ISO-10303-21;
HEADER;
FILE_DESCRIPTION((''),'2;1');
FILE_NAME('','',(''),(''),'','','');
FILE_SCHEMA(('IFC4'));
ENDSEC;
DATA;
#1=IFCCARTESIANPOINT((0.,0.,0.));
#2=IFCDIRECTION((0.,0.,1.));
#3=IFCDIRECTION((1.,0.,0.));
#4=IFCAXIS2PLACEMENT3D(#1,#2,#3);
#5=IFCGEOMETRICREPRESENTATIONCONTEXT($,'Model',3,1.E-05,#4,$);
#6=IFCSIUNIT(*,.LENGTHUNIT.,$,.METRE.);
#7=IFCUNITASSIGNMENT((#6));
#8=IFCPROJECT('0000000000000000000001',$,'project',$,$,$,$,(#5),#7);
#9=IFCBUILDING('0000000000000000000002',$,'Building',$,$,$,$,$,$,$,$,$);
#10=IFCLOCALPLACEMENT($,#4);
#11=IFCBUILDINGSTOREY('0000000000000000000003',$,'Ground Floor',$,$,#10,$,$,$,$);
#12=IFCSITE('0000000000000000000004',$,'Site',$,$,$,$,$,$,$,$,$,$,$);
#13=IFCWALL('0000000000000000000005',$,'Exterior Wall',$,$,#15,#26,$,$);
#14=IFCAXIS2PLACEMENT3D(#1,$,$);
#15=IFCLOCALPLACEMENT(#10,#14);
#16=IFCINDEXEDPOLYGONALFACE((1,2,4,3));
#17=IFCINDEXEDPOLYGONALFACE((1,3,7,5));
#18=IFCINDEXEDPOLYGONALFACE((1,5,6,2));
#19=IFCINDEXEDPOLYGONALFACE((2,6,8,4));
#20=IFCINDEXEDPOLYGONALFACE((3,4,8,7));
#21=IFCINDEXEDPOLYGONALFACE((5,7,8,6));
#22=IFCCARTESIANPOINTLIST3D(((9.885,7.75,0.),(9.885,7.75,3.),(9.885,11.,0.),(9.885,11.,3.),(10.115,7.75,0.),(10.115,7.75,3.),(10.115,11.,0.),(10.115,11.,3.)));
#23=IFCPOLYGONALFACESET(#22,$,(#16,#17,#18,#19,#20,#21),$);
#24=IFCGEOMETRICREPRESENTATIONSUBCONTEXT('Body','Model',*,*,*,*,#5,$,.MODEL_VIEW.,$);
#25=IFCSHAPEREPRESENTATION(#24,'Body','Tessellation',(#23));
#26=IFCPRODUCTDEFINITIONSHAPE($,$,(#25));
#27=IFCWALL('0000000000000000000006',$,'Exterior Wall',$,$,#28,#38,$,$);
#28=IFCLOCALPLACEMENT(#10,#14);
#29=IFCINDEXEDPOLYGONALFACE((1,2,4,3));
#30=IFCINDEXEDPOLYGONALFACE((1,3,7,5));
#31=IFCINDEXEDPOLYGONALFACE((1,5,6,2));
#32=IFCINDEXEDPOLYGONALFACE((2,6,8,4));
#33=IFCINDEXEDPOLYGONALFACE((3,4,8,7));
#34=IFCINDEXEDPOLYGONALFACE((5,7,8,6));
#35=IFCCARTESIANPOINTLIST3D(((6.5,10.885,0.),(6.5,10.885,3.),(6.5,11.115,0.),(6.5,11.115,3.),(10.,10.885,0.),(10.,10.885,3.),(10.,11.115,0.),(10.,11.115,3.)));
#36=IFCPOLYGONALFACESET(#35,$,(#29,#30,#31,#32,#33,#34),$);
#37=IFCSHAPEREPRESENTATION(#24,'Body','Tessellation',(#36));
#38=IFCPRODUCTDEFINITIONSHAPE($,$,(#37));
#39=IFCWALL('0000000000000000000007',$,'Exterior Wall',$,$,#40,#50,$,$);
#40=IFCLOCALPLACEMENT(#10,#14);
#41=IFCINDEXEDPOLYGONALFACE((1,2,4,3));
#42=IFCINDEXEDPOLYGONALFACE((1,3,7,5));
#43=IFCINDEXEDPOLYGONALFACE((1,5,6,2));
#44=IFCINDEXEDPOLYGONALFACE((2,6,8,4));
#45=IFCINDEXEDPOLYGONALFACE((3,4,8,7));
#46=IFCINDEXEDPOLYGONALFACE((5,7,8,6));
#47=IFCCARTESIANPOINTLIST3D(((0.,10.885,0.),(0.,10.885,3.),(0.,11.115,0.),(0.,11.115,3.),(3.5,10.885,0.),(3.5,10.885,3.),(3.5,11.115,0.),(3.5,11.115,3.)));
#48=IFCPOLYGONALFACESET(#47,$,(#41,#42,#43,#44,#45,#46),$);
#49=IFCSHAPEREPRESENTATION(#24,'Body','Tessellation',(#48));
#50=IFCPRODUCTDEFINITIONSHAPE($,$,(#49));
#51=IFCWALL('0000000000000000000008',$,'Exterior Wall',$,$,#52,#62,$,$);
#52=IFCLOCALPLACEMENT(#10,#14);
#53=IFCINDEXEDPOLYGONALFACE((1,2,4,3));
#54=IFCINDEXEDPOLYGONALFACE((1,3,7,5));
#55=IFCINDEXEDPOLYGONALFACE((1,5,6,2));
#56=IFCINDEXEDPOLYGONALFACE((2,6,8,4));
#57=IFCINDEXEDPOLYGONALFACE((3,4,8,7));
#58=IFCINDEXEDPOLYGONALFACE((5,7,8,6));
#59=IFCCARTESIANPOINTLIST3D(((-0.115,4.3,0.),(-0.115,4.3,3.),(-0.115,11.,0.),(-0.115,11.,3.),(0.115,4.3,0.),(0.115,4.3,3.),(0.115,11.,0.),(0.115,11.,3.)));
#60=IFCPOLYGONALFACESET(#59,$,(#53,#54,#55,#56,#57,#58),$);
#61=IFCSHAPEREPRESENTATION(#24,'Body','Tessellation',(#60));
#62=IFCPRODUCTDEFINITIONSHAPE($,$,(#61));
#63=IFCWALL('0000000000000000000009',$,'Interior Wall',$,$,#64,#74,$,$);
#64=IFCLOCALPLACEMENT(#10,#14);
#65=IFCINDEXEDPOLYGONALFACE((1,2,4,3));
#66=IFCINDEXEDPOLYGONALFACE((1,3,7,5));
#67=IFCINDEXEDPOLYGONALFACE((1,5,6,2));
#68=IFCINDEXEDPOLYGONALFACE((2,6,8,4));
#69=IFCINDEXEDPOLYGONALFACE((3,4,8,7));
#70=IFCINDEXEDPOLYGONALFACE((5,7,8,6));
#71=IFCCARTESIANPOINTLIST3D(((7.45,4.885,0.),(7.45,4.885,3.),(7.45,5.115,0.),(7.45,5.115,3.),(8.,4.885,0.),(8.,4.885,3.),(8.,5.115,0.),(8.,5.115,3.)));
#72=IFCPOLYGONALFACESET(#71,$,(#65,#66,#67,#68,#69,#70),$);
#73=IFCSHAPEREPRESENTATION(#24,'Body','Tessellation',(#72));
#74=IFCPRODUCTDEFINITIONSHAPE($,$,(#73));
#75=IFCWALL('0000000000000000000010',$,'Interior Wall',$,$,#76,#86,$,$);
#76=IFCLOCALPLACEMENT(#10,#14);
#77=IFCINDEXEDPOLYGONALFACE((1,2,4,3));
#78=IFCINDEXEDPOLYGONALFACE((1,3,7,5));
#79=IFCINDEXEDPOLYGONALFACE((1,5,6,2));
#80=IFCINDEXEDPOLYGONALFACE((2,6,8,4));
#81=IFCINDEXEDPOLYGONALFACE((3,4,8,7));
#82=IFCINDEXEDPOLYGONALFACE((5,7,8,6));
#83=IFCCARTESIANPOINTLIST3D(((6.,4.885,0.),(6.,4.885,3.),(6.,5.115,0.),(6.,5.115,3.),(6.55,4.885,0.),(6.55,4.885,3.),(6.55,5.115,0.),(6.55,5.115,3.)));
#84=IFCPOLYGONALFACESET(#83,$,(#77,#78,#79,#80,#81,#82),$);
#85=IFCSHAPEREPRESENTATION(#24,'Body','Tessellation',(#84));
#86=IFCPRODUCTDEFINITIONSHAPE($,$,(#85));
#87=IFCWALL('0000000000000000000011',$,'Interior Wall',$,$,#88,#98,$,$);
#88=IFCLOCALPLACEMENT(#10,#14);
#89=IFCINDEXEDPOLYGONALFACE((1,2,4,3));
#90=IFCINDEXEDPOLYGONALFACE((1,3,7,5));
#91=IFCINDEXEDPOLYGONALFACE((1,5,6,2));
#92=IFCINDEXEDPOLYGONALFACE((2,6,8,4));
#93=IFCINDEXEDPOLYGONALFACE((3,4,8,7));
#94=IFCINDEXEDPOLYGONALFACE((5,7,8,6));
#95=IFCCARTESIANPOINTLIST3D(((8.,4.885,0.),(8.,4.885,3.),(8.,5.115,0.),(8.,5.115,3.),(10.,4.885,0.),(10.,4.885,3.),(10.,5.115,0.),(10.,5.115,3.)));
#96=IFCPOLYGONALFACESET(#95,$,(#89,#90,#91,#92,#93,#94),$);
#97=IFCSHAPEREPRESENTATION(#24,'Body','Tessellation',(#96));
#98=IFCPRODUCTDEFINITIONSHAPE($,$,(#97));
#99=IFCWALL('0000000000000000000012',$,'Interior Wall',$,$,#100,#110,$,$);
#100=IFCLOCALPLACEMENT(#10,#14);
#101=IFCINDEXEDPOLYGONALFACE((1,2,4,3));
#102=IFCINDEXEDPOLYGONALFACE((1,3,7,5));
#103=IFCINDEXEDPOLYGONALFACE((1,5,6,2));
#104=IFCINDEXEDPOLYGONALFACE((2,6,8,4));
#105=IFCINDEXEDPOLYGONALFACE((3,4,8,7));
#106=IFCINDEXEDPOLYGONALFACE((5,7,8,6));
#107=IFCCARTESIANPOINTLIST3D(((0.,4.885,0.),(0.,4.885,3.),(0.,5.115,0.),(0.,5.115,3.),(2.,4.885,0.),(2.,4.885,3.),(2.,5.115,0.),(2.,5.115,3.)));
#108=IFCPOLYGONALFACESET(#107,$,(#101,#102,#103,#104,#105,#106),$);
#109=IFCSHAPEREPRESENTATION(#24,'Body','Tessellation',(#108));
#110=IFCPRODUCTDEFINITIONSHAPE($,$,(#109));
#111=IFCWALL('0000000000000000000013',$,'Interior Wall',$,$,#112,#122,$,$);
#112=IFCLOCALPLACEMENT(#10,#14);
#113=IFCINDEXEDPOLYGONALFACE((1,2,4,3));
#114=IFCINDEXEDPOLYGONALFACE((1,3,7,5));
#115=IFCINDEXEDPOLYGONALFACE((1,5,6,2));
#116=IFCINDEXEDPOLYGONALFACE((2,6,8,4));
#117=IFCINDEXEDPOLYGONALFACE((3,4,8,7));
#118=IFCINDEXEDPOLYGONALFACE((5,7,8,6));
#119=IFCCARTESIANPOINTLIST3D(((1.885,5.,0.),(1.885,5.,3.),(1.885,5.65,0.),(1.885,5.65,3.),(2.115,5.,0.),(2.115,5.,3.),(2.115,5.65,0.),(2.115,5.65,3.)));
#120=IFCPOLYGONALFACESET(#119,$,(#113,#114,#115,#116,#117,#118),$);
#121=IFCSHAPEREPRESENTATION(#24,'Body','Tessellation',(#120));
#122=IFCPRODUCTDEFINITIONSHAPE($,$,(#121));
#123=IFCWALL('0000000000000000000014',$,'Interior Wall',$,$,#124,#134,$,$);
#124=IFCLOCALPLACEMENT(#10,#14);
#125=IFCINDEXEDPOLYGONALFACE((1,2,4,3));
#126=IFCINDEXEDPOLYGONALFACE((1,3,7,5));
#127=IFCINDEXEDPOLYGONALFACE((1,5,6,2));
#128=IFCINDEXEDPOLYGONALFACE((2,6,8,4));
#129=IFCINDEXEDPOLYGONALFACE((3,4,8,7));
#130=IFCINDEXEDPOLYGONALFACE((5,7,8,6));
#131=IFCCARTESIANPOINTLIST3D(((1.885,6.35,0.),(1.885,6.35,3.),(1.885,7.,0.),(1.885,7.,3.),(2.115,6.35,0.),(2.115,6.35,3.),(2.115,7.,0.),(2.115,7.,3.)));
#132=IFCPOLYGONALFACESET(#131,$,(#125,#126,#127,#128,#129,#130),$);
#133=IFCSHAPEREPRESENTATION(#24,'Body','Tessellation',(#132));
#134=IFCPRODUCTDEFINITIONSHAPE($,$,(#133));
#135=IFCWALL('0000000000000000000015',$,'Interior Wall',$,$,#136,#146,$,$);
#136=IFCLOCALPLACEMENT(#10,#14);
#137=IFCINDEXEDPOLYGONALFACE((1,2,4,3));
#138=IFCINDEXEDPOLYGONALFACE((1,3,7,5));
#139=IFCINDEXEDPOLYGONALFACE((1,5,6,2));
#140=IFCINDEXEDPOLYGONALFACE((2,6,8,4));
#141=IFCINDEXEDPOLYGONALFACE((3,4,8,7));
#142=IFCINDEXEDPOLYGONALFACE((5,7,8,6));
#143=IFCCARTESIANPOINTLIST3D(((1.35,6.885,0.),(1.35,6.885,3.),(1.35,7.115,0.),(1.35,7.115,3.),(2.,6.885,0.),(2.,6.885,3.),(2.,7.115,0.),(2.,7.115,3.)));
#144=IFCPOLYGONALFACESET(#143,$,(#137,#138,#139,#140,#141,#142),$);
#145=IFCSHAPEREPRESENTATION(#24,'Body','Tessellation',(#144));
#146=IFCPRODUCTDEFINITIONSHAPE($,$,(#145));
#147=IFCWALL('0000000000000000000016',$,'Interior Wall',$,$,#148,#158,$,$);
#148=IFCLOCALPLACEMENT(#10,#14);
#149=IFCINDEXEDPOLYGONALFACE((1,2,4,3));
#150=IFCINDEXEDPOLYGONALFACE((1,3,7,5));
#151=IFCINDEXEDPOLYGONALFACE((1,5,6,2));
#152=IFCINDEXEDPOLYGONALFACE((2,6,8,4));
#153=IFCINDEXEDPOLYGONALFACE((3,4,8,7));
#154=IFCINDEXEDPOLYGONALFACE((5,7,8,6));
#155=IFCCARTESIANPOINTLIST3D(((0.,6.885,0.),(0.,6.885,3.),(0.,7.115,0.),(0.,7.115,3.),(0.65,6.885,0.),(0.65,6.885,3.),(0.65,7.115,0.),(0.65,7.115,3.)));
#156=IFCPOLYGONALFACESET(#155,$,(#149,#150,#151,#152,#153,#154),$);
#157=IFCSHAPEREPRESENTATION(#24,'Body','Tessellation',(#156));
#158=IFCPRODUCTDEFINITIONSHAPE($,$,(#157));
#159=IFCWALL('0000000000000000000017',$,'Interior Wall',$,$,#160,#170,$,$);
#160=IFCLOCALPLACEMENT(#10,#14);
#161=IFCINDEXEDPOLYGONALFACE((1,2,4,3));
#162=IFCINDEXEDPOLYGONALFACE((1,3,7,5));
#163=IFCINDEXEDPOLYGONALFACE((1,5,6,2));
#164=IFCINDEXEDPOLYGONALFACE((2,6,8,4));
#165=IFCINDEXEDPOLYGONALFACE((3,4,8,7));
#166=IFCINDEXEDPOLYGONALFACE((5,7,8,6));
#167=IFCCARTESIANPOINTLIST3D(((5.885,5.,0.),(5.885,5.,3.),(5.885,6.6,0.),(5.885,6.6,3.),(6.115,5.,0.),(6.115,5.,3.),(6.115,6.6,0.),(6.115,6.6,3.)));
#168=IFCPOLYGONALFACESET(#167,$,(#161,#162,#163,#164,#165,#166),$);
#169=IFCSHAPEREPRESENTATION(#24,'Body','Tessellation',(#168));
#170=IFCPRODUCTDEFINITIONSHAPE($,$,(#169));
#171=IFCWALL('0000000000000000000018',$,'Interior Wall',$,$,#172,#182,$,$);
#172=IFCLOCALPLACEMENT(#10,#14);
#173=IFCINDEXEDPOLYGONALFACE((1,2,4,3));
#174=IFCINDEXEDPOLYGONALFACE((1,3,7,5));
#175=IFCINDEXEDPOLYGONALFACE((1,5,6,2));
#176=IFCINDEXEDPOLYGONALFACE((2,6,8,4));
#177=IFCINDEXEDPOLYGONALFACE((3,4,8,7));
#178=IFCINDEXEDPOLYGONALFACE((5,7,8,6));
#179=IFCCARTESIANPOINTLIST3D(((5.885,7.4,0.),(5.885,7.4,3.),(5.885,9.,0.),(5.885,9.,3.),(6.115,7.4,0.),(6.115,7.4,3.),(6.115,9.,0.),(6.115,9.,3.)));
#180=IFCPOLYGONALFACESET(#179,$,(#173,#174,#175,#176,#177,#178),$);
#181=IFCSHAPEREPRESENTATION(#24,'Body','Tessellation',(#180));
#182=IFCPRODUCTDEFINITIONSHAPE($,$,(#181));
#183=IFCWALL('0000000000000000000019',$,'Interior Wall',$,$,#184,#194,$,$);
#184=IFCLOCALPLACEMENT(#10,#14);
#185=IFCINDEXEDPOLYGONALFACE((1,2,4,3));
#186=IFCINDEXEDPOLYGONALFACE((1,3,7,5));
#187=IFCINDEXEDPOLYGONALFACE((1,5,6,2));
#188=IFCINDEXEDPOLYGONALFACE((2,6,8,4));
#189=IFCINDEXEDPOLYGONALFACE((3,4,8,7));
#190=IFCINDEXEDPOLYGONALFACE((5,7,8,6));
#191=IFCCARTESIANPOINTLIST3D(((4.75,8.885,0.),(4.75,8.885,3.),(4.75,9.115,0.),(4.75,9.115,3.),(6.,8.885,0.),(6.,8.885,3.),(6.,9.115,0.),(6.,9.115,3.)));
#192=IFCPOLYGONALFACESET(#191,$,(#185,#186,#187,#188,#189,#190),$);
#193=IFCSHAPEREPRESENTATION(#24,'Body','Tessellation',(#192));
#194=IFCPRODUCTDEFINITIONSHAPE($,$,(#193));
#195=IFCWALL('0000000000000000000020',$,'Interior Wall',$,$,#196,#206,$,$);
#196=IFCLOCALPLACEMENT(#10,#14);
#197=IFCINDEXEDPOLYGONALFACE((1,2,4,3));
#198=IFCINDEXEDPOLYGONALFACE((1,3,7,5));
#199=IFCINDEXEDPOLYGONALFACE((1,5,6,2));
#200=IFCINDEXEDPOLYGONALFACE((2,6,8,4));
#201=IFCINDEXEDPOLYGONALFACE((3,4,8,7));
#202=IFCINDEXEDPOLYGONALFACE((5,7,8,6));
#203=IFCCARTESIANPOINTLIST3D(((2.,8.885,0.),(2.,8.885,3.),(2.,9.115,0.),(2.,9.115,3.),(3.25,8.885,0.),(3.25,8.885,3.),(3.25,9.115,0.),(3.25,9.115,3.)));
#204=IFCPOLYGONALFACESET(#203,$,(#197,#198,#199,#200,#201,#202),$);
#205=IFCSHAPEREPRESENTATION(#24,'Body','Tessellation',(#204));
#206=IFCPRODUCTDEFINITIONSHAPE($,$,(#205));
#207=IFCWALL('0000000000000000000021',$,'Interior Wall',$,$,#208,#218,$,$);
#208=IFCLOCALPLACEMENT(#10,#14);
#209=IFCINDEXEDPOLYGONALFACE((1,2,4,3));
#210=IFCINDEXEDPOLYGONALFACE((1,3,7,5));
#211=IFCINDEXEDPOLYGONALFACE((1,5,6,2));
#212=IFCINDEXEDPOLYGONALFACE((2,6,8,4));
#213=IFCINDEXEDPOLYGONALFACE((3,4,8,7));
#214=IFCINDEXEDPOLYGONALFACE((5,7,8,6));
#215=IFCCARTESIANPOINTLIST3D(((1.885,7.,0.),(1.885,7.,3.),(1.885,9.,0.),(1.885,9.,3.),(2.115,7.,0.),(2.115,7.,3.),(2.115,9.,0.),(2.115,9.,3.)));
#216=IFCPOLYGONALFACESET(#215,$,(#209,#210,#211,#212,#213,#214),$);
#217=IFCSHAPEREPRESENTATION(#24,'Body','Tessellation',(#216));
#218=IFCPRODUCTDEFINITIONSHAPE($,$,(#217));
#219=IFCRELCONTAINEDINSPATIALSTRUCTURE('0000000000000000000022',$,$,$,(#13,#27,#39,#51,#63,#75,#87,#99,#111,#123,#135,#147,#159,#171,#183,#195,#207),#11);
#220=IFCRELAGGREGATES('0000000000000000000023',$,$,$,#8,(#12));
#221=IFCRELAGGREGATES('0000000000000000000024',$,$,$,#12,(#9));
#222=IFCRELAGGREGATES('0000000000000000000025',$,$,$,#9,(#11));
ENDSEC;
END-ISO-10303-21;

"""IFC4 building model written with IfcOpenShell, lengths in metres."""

from ifc_helpers import new_model, si_unit, frame, origin_with_axes, place, context, subcontext, project, spatial, indexed_curve, outline, extrude, element, save


model = new_model("IFC4")

# Units and contexts
model_context = context("Model", 3, precision=1e-05, world=origin_with_axes())
body_context = subcontext(model_context, "Body", "Model", "MODEL_VIEW")
ifc_project = project(units=[si_unit("LENGTHUNIT", "METRE")], contexts=[model_context])

# Site, building, storey
site = spatial("IfcSite", under=ifc_project, Name="Site")
building = spatial("IfcBuilding", under=site, Name="Building")
storey_placement = place(None, origin_with_axes())
storey = spatial("IfcBuildingStorey", under=building, at=storey_placement, Name="Ground Floor")

# Walls
wall_1_placement = place(storey_placement, frame((10.0, 7.75, 0.0), z_axis=(0.0, 0.0, 1.0), x_axis=(0.0, 1.0, 0.0)))
element("IfcWall", 1, at=wall_1_placement, inside=storey, Name="Exterior Wall", context=body_context, shape_type="SweptSolid", body=[
    extrude(outline(indexed_curve([(0.0, 0.0), (0.0, 0.23), (3.25, 0.23), (3.25, 0.0), (0.0, 0.0)], self_intersect=False)), frame((0.0, -0.115, 0.0), z_axis=(0.0, 0.0, 1.0), x_axis=(1.0, 0.0, 0.0)), (0.0, 0.0, 1.0), 3.0),
])
for number, where, z_axis, x_axis, name in (
    (2, (10.0, 11.0, 0.0), (0.0, 0.0, 1.0), (-1.0, 0.0, 0.0), "Exterior Wall"),
    (3, (3.5, 11.0, 0.0), (0.0, 0.0, 1.0), (-1.0, 0.0, 0.0), "Exterior Wall"),
):
    element("IfcWall", number, at=place(storey_placement, frame(where, z_axis=z_axis, x_axis=x_axis)), inside=storey, Name=name, context=body_context, shape_type="SweptSolid", body=[
        extrude(outline(indexed_curve([(0.0, 0.0), (0.0, 0.23), (3.5, 0.23), (3.5, 0.0), (0.0, 0.0)], self_intersect=False)), frame((0.0, -0.115, 0.0), z_axis=(0.0, 0.0, 1.0), x_axis=(1.0, 0.0, 0.0)), (0.0, 0.0, 1.0), 3.0),
    ])
wall_2_placement = place(storey_placement, frame((0.0, 11.0, 0.0), z_axis=(0.0, 0.0, 1.0), x_axis=(0.0, -1.0, 0.0)))
element("IfcWall", 4, at=wall_2_placement, inside=storey, Name="Exterior Wall", context=body_context, shape_type="SweptSolid", body=[
    extrude(outline(indexed_curve([(0.0, 0.0), (0.0, 0.23), (6.7, 0.23), (6.7, 0.0), (0.0, 0.0)], self_intersect=False)), frame((0.0, -0.115, 0.0), z_axis=(0.0, 0.0, 1.0), x_axis=(1.0, 0.0, 0.0)), (0.0, 0.0, 1.0), 3.0),
])
for number, where, z_axis, x_axis, name in (
    (5, (8.0, 5.0, 0.0), (0.0, 0.0, 1.0), (-1.0, 0.0, 0.0), "Interior Wall"),
    (6, (6.55, 5.0, 0.0), (0.0, 0.0, 1.0), (-1.0, 0.0, 0.0), "Interior Wall"),
):
    element("IfcWall", number, at=place(storey_placement, frame(where, z_axis=z_axis, x_axis=x_axis)), inside=storey, Name=name, context=body_context, shape_type="SweptSolid", body=[
        extrude(outline(indexed_curve([(0.0, 0.0), (0.0, 0.23), (0.55, 0.23), (0.55, 0.0), (0.0, 0.0)], self_intersect=False)), frame((0.0, -0.115, 0.0), z_axis=(0.0, 0.0, 1.0), x_axis=(1.0, 0.0, 0.0)), (0.0, 0.0, 1.0), 3.0),
    ])
for number, where, z_axis, x_axis, name in (
    (7, (10.0, 5.0, 0.0), (0.0, 0.0, 1.0), (-1.0, 0.0, 0.0), "Interior Wall"),
    (8, (2.0, 5.0, 0.0), (0.0, 0.0, 1.0), (-1.0, 0.0, 0.0), "Interior Wall"),
):
    element("IfcWall", number, at=place(storey_placement, frame(where, z_axis=z_axis, x_axis=x_axis)), inside=storey, Name=name, context=body_context, shape_type="SweptSolid", body=[
        extrude(outline(indexed_curve([(0.0, 0.0), (0.0, 0.23), (2.0, 0.23), (2.0, 0.0), (0.0, 0.0)], self_intersect=False)), frame((0.0, -0.115, 0.0), z_axis=(0.0, 0.0, 1.0), x_axis=(1.0, 0.0, 0.0)), (0.0, 0.0, 1.0), 3.0),
    ])
for number, where, z_axis, x_axis, name in (
    (9, (2.0, 5.0, 0.0), (0.0, 0.0, 1.0), (0.0, 1.0, 0.0), "Interior Wall"),
    (10, (2.0, 6.35, 0.0), (0.0, 0.0, 1.0), (0.0, 1.0, 0.0), "Interior Wall"),
):
    element("IfcWall", number, at=place(storey_placement, frame(where, z_axis=z_axis, x_axis=x_axis)), inside=storey, Name=name, context=body_context, shape_type="SweptSolid", body=[
        extrude(outline(indexed_curve([(0.0, 0.0), (0.0, 0.23), (0.65, 0.23), (0.65, 0.0), (0.0, 0.0)], self_intersect=False)), frame((0.0, -0.115, 0.0), z_axis=(0.0, 0.0, 1.0), x_axis=(1.0, 0.0, 0.0)), (0.0, 0.0, 1.0), 3.0),
    ])
for number, where, z_axis, x_axis, name in (
    (11, (2.0, 7.0, 0.0), (0.0, 0.0, 1.0), (-1.0, 0.0, 0.0), "Interior Wall"),
    (12, (0.65, 7.0, 0.0), (0.0, 0.0, 1.0), (-1.0, 0.0, 0.0), "Interior Wall"),
):
    element("IfcWall", number, at=place(storey_placement, frame(where, z_axis=z_axis, x_axis=x_axis)), inside=storey, Name=name, context=body_context, shape_type="SweptSolid", body=[
        extrude(outline(indexed_curve([(0.0, 0.0), (0.0, 0.23), (0.65, 0.23), (0.65, 0.0), (0.0, 0.0)], self_intersect=False)), frame((0.0, -0.115, 0.0), z_axis=(0.0, 0.0, 1.0), x_axis=(1.0, 0.0, 0.0)), (0.0, 0.0, 1.0), 3.0),
    ])
for number, where, z_axis, x_axis, name in (
    (13, (6.0, 5.0, 0.0), (0.0, 0.0, 1.0), (0.0, 1.0, 0.0), "Interior Wall"),
    (14, (6.0, 7.4, 0.0), (0.0, 0.0, 1.0), (0.0, 1.0, 0.0), "Interior Wall"),
):
    element("IfcWall", number, at=place(storey_placement, frame(where, z_axis=z_axis, x_axis=x_axis)), inside=storey, Name=name, context=body_context, shape_type="SweptSolid", body=[
        extrude(outline(indexed_curve([(0.0, 0.0), (0.0, 0.23), (1.6, 0.23), (1.6, 0.0), (0.0, 0.0)], self_intersect=False)), frame((0.0, -0.115, 0.0), z_axis=(0.0, 0.0, 1.0), x_axis=(1.0, 0.0, 0.0)), (0.0, 0.0, 1.0), 3.0),
    ])
for number, where, z_axis, x_axis, name in (
    (15, (6.0, 9.0, 0.0), (0.0, 0.0, 1.0), (-1.0, 0.0, 0.0), "Interior Wall"),
    (16, (3.25, 9.0, 0.0), (0.0, 0.0, 1.0), (-1.0, 0.0, 0.0), "Interior Wall"),
):
    element("IfcWall", number, at=place(storey_placement, frame(where, z_axis=z_axis, x_axis=x_axis)), inside=storey, Name=name, context=body_context, shape_type="SweptSolid", body=[
        extrude(outline(indexed_curve([(0.0, 0.0), (0.0, 0.23), (1.25, 0.23), (1.25, 0.0), (0.0, 0.0)], self_intersect=False)), frame((0.0, -0.115, 0.0), z_axis=(0.0, 0.0, 1.0), x_axis=(1.0, 0.0, 0.0)), (0.0, 0.0, 1.0), 3.0),
    ])
wall_3_placement = place(storey_placement, frame((2.0, 9.0, 0.0), z_axis=(0.0, 0.0, 1.0), x_axis=(0.0, -1.0, 0.0)))
element("IfcWall", 17, at=wall_3_placement, inside=storey, Name="Interior Wall", context=body_context, shape_type="SweptSolid", body=[
    extrude(outline(indexed_curve([(0.0, 0.0), (0.0, 0.23), (2.0, 0.23), (2.0, 0.0), (0.0, 0.0)], self_intersect=False)), frame((0.0, -0.115, 0.0), z_axis=(0.0, 0.0, 1.0), x_axis=(1.0, 0.0, 0.0)), (0.0, 0.0, 1.0), 3.0),
])

save(model, "model.ifc")
